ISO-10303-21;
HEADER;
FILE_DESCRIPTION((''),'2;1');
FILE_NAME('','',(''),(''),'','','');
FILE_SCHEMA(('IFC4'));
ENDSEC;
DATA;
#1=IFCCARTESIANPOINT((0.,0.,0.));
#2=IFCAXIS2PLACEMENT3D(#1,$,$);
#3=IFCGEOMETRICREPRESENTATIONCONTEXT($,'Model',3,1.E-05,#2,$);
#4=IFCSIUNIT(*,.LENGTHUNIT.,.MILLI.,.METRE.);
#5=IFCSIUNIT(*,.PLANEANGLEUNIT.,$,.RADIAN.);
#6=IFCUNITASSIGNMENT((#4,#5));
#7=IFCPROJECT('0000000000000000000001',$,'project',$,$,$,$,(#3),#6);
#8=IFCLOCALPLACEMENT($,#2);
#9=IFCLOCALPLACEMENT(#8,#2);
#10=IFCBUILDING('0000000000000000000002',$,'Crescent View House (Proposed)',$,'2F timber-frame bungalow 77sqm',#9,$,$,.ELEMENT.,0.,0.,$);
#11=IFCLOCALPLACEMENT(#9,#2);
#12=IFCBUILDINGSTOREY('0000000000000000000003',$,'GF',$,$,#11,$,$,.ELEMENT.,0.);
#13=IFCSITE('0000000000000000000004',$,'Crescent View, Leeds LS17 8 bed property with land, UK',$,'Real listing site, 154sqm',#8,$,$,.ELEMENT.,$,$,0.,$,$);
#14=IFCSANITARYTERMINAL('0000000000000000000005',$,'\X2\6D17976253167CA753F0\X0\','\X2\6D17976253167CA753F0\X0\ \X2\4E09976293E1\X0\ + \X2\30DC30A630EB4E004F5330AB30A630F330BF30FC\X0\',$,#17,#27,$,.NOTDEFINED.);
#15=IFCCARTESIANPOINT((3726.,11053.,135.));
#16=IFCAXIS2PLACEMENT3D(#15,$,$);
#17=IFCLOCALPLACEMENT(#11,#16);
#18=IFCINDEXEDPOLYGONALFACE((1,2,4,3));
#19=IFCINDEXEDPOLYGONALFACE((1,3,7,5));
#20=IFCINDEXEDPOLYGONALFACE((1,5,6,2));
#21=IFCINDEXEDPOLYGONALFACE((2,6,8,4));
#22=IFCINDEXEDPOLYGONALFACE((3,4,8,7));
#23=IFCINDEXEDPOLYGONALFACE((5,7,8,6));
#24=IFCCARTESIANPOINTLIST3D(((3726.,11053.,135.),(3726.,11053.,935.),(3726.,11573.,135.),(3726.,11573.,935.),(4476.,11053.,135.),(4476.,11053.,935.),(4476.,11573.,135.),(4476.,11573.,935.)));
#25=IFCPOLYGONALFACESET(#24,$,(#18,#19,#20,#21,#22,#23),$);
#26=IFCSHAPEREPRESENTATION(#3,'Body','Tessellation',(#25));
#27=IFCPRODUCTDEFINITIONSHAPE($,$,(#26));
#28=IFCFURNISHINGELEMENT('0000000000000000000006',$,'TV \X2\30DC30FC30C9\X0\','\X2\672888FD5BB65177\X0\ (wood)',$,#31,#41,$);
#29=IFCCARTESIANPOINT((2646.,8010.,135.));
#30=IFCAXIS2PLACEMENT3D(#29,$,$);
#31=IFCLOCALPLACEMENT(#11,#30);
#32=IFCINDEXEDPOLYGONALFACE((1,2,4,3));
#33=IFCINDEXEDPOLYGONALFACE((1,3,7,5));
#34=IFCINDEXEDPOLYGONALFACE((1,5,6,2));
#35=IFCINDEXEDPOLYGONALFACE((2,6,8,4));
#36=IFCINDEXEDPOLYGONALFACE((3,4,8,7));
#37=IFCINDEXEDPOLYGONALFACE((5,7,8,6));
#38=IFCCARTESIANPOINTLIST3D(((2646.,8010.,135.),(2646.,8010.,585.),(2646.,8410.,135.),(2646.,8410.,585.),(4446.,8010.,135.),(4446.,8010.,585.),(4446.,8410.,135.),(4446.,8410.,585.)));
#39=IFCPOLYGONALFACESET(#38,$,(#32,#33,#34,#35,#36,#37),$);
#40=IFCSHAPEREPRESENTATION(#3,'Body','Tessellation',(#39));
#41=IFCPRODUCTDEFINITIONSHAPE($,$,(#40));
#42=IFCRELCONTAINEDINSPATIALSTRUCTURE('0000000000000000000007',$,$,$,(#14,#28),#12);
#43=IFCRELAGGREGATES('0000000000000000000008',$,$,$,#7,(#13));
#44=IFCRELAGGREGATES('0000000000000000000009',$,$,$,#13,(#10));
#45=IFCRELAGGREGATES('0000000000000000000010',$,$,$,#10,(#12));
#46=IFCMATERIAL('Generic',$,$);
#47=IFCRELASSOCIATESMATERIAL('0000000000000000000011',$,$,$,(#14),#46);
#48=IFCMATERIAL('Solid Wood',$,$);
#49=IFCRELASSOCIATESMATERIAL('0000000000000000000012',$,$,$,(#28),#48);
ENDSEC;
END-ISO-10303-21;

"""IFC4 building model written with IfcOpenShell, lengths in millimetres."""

from ifc_helpers import new_model, si_unit, frame, frame_2d, origin, place, context, project, spatial, rectangle, extrude, material, element, save


model = new_model("IFC4")

# Units and contexts
model_context = context("Model", 3, precision=1e-05, world=origin())
ifc_project = project(units=[si_unit("LENGTHUNIT", "METRE", prefix="MILLI"), si_unit("PLANEANGLEUNIT", "RADIAN")], contexts=[model_context])

# Site, building, storey
site_placement = place(None, origin())
site = spatial("IfcSite", under=ifc_project, at=site_placement, Name="Crescent View, Leeds LS17 8 bed property with land, UK", ObjectType="Real listing site, 154sqm", CompositionType="ELEMENT", RefElevation=0.0)
building_placement = place(site_placement, origin())
building = spatial("IfcBuilding", under=site, at=building_placement, Name="Crescent View House (Proposed)", ObjectType="2F timber-frame bungalow 77sqm", CompositionType="ELEMENT", ElevationOfRefHeight=0.0, ElevationOfTerrain=0.0)
storey_placement = place(building_placement, origin())
storey = spatial("IfcBuildingStorey", under=building, at=storey_placement, Name="GF", CompositionType="ELEMENT", Elevation=0.0)

# Shared definitions
ifc_material_1 = material(Name="Solid Wood")

# Shared definitions
ifc_material_2 = material(Name="Generic")

# Sanitary terminal
sanitary_terminal_1_placement = place(storey_placement, frame((3726.0, 11053.0, 135.0)))
element("IfcSanitaryTerminal", 1, at=sanitary_terminal_1_placement, inside=storey, material=ifc_material_2, Name="洗面化粧台", Description="洗面化粧台 三面鏡 + ボウル一体カウンター", PredefinedType="NOTDEFINED", context=model_context, shape_type="SweptSolid", body=[
    extrude(rectangle(XDim=750.0, YDim=520.0, at=frame_2d((375.0, 260.0))), frame((3726.0, 11053.0, 135.0)), (0.0, 0.0, 1.0), 800.0),
])

# Furnishing element
furnishing_placement = place(storey_placement, frame((2646.0, 8010.0, 135.0)))
element("IfcFurnishingElement", 2, at=furnishing_placement, inside=storey, material=ifc_material_1, Name="TV ボード", Description="木製家具 (wood)", context=model_context, shape_type="SweptSolid", body=[
    extrude(rectangle(XDim=1800.0, YDim=400.0, at=frame_2d((900.0, 200.0))), frame((2646.0, 8010.0, 135.0)), (0.0, 0.0, 1.0), 450.0),
])

save(model, "model.ifc")
